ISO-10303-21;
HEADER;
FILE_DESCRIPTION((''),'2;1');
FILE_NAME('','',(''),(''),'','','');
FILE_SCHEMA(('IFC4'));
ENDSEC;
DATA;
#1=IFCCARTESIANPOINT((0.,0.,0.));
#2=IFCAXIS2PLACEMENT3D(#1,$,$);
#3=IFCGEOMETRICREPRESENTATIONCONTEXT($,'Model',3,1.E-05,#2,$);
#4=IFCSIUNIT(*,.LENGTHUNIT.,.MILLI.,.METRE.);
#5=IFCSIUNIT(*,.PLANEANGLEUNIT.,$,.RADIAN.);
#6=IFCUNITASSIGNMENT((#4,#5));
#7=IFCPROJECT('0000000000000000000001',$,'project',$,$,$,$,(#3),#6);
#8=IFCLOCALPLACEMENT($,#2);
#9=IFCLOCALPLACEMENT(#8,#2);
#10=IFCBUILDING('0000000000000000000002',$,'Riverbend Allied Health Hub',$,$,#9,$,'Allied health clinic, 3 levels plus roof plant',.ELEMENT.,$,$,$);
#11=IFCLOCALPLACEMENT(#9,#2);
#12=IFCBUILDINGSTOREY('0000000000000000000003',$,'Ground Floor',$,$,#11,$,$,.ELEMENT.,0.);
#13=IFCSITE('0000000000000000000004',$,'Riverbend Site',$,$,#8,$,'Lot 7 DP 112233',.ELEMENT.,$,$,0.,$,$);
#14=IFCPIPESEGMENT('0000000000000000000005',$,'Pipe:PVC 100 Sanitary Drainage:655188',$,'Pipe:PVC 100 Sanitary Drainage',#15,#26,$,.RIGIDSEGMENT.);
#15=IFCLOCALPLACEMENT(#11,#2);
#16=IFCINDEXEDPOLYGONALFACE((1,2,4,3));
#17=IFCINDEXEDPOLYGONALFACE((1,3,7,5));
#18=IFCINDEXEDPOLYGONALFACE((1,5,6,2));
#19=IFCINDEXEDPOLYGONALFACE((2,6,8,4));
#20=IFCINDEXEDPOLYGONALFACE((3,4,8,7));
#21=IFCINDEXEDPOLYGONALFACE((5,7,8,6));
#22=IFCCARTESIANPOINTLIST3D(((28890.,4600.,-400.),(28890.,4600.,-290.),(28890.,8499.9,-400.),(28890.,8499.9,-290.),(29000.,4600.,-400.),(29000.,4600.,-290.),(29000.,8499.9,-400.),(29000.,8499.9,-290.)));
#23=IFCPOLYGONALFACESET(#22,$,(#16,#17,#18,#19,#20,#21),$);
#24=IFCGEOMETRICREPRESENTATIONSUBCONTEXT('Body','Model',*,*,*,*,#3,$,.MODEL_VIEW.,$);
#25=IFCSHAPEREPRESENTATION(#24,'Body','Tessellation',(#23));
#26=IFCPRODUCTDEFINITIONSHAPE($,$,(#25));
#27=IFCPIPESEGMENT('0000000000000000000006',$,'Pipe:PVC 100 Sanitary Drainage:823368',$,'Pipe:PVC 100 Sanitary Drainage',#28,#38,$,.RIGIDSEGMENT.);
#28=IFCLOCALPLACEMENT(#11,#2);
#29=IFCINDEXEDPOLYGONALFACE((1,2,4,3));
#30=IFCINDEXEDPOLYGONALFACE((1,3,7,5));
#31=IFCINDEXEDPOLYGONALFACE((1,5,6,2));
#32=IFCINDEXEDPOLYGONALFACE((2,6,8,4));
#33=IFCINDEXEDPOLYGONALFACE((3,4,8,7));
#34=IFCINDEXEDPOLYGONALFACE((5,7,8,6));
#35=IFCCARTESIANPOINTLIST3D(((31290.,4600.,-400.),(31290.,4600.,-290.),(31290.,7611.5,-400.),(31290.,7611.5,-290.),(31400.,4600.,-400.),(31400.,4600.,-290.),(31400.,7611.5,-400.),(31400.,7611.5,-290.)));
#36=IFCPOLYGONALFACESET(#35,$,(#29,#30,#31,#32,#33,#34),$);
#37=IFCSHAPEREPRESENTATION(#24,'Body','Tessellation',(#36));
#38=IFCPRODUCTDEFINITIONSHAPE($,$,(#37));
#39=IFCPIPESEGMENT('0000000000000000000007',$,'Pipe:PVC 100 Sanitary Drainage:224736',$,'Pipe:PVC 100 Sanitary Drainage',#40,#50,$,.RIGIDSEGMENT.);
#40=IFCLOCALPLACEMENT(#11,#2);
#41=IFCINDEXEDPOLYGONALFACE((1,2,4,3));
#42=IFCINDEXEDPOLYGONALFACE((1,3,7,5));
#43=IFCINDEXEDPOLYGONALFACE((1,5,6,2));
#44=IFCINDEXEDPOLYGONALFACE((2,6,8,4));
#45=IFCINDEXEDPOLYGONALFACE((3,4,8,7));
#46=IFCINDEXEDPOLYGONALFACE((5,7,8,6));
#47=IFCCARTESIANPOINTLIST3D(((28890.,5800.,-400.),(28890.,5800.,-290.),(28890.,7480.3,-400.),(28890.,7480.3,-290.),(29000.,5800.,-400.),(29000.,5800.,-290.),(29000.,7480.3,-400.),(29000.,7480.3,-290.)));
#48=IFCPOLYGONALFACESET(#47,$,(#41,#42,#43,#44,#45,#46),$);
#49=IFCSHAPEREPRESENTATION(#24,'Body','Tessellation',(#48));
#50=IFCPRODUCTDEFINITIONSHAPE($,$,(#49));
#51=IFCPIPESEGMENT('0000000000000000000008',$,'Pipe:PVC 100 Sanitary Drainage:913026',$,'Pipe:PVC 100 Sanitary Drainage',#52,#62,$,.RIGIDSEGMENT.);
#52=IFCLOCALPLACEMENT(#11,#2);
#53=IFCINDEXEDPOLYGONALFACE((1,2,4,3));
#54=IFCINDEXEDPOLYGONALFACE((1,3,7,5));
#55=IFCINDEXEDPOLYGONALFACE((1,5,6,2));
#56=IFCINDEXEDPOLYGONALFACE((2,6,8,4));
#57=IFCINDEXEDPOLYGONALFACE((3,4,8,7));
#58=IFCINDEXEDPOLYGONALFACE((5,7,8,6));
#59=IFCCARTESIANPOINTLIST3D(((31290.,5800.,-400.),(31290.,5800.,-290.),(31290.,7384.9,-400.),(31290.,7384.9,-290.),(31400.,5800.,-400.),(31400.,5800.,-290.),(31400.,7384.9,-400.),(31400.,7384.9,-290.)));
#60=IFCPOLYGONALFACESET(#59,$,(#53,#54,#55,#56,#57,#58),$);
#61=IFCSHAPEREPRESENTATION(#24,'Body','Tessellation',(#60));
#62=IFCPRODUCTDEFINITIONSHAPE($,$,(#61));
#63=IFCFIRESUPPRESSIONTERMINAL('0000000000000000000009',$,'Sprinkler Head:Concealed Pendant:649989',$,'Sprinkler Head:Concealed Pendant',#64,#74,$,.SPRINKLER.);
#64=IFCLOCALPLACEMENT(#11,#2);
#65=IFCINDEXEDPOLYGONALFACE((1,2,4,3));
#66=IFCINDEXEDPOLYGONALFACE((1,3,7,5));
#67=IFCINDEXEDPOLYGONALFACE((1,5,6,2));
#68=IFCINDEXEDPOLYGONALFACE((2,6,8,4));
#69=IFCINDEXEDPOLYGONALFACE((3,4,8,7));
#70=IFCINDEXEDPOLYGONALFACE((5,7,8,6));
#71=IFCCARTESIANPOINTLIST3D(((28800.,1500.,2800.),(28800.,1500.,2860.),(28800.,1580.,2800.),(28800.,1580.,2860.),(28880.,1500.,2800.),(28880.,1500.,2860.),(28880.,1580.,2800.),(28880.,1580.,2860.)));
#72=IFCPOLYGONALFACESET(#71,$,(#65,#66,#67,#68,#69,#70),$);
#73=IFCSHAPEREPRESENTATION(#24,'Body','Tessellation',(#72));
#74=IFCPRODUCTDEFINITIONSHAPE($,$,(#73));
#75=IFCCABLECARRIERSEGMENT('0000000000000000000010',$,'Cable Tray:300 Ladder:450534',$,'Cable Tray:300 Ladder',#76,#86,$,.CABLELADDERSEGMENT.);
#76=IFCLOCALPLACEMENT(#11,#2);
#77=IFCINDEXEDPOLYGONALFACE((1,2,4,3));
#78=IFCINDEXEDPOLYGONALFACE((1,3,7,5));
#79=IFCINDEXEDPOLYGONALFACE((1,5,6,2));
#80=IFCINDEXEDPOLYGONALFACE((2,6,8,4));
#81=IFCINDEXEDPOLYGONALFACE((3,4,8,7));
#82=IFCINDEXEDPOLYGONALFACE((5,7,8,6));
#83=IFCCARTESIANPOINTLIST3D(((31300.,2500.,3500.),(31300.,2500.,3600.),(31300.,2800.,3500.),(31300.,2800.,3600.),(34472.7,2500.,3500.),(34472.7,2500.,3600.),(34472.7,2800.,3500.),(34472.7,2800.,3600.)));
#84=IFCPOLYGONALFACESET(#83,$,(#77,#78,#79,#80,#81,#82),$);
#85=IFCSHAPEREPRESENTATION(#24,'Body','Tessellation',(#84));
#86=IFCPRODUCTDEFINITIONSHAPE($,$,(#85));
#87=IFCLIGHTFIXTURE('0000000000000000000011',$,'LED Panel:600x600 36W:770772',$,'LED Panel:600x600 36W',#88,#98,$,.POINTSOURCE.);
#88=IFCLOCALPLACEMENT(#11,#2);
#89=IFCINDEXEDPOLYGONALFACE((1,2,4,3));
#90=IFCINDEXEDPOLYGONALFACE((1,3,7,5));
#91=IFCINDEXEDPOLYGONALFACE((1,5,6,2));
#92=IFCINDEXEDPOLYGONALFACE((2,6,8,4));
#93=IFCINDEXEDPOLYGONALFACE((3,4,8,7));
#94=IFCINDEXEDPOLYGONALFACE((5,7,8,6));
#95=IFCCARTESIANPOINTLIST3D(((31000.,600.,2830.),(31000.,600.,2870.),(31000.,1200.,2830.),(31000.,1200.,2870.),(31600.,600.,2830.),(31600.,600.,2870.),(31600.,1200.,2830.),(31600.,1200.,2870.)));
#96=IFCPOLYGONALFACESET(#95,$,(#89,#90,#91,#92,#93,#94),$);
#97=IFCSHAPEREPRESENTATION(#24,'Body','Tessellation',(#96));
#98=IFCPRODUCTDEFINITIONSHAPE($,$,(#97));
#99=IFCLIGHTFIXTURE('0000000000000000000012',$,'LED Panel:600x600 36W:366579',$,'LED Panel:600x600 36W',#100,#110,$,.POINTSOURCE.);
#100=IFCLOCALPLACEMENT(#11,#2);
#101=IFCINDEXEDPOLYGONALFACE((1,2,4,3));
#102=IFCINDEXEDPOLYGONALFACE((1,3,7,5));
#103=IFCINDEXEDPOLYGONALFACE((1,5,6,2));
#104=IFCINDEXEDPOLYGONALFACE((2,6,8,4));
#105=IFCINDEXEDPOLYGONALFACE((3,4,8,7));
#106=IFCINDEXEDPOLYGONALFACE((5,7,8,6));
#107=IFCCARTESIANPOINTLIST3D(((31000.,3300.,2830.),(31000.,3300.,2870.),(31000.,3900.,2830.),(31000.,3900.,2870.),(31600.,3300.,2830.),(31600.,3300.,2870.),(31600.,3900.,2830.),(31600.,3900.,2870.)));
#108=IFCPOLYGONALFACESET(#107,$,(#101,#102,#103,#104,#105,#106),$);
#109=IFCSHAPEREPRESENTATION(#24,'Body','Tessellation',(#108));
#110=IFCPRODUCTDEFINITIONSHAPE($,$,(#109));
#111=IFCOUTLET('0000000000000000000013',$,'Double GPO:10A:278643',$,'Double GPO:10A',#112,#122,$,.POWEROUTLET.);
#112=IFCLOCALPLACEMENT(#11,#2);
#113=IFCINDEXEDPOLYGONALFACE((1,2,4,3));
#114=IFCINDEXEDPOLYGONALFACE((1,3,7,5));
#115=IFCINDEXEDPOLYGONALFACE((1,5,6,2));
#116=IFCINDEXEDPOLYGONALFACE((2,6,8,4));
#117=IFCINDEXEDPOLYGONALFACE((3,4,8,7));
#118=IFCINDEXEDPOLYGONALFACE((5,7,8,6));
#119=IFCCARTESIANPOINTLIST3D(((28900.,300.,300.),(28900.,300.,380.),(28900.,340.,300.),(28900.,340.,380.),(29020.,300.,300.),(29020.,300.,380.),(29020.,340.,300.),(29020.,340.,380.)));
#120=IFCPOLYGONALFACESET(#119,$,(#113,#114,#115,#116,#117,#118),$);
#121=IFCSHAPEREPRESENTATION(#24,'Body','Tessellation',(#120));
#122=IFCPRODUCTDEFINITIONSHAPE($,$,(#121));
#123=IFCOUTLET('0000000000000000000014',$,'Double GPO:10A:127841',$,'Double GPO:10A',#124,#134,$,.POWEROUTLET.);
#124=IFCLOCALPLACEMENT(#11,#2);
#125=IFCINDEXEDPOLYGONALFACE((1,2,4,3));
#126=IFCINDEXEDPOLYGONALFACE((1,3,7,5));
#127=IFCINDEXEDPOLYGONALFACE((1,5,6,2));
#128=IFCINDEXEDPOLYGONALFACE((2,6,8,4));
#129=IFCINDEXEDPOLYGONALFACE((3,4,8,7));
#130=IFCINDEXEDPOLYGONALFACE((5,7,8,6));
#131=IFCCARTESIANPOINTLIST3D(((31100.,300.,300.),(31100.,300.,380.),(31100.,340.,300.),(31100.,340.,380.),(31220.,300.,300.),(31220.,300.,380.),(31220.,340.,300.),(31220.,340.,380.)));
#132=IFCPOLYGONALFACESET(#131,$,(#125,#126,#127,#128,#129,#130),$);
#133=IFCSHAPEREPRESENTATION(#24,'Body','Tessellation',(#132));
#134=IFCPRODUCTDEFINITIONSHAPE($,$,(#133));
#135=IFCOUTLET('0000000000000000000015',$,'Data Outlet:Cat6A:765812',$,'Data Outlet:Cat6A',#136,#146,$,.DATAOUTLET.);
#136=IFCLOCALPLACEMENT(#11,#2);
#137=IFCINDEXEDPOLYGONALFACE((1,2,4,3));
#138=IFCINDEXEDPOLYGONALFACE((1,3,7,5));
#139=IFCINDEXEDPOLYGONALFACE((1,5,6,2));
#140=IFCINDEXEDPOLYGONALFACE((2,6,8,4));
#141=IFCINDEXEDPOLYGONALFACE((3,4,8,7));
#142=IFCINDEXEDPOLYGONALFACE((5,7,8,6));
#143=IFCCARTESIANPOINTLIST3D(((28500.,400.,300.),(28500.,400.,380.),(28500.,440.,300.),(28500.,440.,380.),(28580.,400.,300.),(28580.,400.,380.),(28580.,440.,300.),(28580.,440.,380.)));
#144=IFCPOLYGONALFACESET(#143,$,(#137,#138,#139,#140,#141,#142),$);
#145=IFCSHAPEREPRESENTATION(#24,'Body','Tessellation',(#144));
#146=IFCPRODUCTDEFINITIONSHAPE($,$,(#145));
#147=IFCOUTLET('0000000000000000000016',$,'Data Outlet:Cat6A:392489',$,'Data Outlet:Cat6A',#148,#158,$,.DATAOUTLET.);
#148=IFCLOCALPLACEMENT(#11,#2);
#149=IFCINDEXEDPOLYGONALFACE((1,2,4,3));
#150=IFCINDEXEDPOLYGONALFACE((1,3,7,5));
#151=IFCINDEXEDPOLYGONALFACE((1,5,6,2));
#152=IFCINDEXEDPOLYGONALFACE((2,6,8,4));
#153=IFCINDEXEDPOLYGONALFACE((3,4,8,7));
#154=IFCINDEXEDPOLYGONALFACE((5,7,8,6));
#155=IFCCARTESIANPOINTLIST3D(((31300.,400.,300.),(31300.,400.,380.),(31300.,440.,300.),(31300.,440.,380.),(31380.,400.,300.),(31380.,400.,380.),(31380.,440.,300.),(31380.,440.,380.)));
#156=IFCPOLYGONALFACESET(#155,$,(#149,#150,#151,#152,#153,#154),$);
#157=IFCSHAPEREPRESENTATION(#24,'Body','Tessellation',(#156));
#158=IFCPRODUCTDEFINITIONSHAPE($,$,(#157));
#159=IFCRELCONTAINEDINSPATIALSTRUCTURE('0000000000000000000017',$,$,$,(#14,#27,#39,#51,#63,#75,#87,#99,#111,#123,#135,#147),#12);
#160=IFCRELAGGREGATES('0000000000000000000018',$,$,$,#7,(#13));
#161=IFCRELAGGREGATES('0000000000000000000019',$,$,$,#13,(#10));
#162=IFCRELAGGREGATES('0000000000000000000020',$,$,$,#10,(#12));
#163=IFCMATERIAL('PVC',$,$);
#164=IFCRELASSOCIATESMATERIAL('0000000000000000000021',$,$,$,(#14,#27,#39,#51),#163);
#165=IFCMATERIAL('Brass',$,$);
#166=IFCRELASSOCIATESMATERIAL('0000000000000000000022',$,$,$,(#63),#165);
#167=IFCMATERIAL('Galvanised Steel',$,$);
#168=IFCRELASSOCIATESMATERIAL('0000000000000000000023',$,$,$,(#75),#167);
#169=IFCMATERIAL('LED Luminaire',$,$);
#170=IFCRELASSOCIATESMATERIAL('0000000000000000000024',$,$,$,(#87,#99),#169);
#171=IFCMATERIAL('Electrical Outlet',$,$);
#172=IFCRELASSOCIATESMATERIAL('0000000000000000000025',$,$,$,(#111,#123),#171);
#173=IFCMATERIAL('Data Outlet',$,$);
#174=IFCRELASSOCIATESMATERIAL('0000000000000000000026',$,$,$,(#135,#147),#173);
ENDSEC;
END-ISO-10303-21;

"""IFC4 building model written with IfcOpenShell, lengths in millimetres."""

from ifc_helpers import new_model, si_unit, frame, frame_2d, origin, place, context, subcontext, project, spatial, rectangle, extrude, material, element, save


model = new_model("IFC4")

# Units and contexts
model_context = context("Model", 3, precision=1e-05, world=origin())
body_context = subcontext(model_context, "Body", "Model", "MODEL_VIEW")
ifc_project = project(units=[si_unit("LENGTHUNIT", "METRE", prefix="MILLI"), si_unit("PLANEANGLEUNIT", "RADIAN")], contexts=[model_context])

# Site, building, storey
site_placement = place(None, origin())
site = spatial("IfcSite", under=ifc_project, at=site_placement, Name="Riverbend Site", LongName="Lot 7 DP 112233", CompositionType="ELEMENT", RefElevation=0.0)
building_placement = place(site_placement, origin())
building = spatial("IfcBuilding", under=site, at=building_placement, Name="Riverbend Allied Health Hub", LongName="Allied health clinic, 3 levels plus roof plant", CompositionType="ELEMENT")
storey_placement = place(building_placement, origin())
storey = spatial("IfcBuildingStorey", under=building, at=storey_placement, Name="Ground Floor", CompositionType="ELEMENT", Elevation=0.0)

# Shared definitions
ifc_material_1 = material(Name="Galvanised Steel")

# Pipe segments
ifc_material_2 = material(Name="PVC")
pipe_segment_1_placement = place(storey_placement, frame((29000.0, 4600.0, -400.0), z_axis=(0.0, 0.0, 1.0), x_axis=(0.0, 1.0, 0.0)))
element("IfcPipeSegment", 1, at=pipe_segment_1_placement, inside=storey, material=ifc_material_2, Name="Pipe:PVC 100 Sanitary Drainage:655188", ObjectType="Pipe:PVC 100 Sanitary Drainage", PredefinedType="RIGIDSEGMENT", context=body_context, shape_type="SweptSolid", body=[
    extrude(rectangle(XDim=3899.9, YDim=110.0, at=frame_2d((1949.9, 55.0))), origin(), (0.0, 0.0, 1.0), 110.0),
])
pipe_segment_2_placement = place(storey_placement, frame((31400.0, 4600.0, -400.0), z_axis=(0.0, 0.0, 1.0), x_axis=(0.0, 1.0, 0.0)))
element("IfcPipeSegment", 2, at=pipe_segment_2_placement, inside=storey, material=ifc_material_2, Name="Pipe:PVC 100 Sanitary Drainage:823368", ObjectType="Pipe:PVC 100 Sanitary Drainage", PredefinedType="RIGIDSEGMENT", context=body_context, shape_type="SweptSolid", body=[
    extrude(rectangle(XDim=3011.5, YDim=110.0, at=frame_2d((1505.8, 55.0))), origin(), (0.0, 0.0, 1.0), 110.0),
])
pipe_segment_3_placement = place(storey_placement, frame((29000.0, 5800.0, -400.0), z_axis=(0.0, 0.0, 1.0), x_axis=(0.0, 1.0, 0.0)))
element("IfcPipeSegment", 3, at=pipe_segment_3_placement, inside=storey, material=ifc_material_2, Name="Pipe:PVC 100 Sanitary Drainage:224736", ObjectType="Pipe:PVC 100 Sanitary Drainage", PredefinedType="RIGIDSEGMENT", context=body_context, shape_type="SweptSolid", body=[
    extrude(rectangle(XDim=1680.3, YDim=110.0, at=frame_2d((840.2, 55.0))), origin(), (0.0, 0.0, 1.0), 110.0),
])
pipe_segment_4_placement = place(storey_placement, frame((31400.0, 5800.0, -400.0), z_axis=(0.0, 0.0, 1.0), x_axis=(0.0, 1.0, 0.0)))
element("IfcPipeSegment", 4, at=pipe_segment_4_placement, inside=storey, material=ifc_material_2, Name="Pipe:PVC 100 Sanitary Drainage:913026", ObjectType="Pipe:PVC 100 Sanitary Drainage", PredefinedType="RIGIDSEGMENT", context=body_context, shape_type="SweptSolid", body=[
    extrude(rectangle(XDim=1584.9, YDim=110.0, at=frame_2d((792.5, 55.0))), origin(), (0.0, 0.0, 1.0), 110.0),
])

# Fire suppression terminal
ifc_material_3 = material(Name="Brass")
fire_suppression_terminal_placement = place(storey_placement, frame((28800.0, 1500.0, 2800.0)))
element("IfcFireSuppressionTerminal", 5, at=fire_suppression_terminal_placement, inside=storey, material=ifc_material_3, Name="Sprinkler Head:Concealed Pendant:649989", ObjectType="Sprinkler Head:Concealed Pendant", PredefinedType="SPRINKLER", context=body_context, shape_type="SweptSolid", body=[
    extrude(rectangle(XDim=80.0, YDim=80.0, at=frame_2d((40.0, 40.0))), origin(), (0.0, 0.0, 1.0), 60.0),
])

# Cable carrier segment
cable_carrier_segment_placement = place(storey_placement, frame((31300.0, 2500.0, 3500.0)))
element("IfcCableCarrierSegment", 6, at=cable_carrier_segment_placement, inside=storey, material=ifc_material_1, Name="Cable Tray:300 Ladder:450534", ObjectType="Cable Tray:300 Ladder", PredefinedType="CABLELADDERSEGMENT", context=body_context, shape_type="SweptSolid", body=[
    extrude(rectangle(XDim=3172.7, YDim=300.0, at=frame_2d((1586.3, 150.0))), origin(), (0.0, 0.0, 1.0), 100.0),
])

# Light fixtures
ifc_material_4 = material(Name="LED Luminaire")
for number, where, name in (
    (7, (31000.0, 600.0, 2830.0), "LED Panel:600x600 36W:770772"),
    (8, (31000.0, 3300.0, 2830.0), "LED Panel:600x600 36W:366579"),
):
    element("IfcLightFixture", number, at=place(storey_placement, frame(where)), inside=storey, material=ifc_material_4, Name=name, ObjectType="LED Panel:600x600 36W", PredefinedType="POINTSOURCE", context=body_context, shape_type="SweptSolid", body=[
        extrude(rectangle(XDim=600.0, YDim=600.0, at=frame_2d((300.0, 300.0))), origin(), (0.0, 0.0, 1.0), 40.0),
    ])

# Outlets
ifc_material_5 = material(Name="Electrical Outlet")
for number, where, name in (
    (9, (28900.0, 300.0, 300.0), "Double GPO:10A:278643"),
    (10, (31100.0, 300.0, 300.0), "Double GPO:10A:127841"),
):
    element("IfcOutlet", number, at=place(storey_placement, frame(where)), inside=storey, material=ifc_material_5, Name=name, ObjectType="Double GPO:10A", PredefinedType="POWEROUTLET", context=body_context, shape_type="SweptSolid", body=[
        extrude(rectangle(XDim=120.0, YDim=40.0, at=frame_2d((60.0, 20.0))), origin(), (0.0, 0.0, 1.0), 80.0),
    ])
ifc_material_6 = material(Name="Data Outlet")
for number, where, name in (
    (11, (28500.0, 400.0, 300.0), "Data Outlet:Cat6A:765812"),
    (12, (31300.0, 400.0, 300.0), "Data Outlet:Cat6A:392489"),
):
    element("IfcOutlet", number, at=place(storey_placement, frame(where)), inside=storey, material=ifc_material_6, Name=name, ObjectType="Data Outlet:Cat6A", PredefinedType="DATAOUTLET", context=body_context, shape_type="SweptSolid", body=[
        extrude(rectangle(XDim=80.0, YDim=40.0, at=frame_2d((40.0, 20.0))), origin(), (0.0, 0.0, 1.0), 80.0),
    ])

save(model, "model.ifc")
